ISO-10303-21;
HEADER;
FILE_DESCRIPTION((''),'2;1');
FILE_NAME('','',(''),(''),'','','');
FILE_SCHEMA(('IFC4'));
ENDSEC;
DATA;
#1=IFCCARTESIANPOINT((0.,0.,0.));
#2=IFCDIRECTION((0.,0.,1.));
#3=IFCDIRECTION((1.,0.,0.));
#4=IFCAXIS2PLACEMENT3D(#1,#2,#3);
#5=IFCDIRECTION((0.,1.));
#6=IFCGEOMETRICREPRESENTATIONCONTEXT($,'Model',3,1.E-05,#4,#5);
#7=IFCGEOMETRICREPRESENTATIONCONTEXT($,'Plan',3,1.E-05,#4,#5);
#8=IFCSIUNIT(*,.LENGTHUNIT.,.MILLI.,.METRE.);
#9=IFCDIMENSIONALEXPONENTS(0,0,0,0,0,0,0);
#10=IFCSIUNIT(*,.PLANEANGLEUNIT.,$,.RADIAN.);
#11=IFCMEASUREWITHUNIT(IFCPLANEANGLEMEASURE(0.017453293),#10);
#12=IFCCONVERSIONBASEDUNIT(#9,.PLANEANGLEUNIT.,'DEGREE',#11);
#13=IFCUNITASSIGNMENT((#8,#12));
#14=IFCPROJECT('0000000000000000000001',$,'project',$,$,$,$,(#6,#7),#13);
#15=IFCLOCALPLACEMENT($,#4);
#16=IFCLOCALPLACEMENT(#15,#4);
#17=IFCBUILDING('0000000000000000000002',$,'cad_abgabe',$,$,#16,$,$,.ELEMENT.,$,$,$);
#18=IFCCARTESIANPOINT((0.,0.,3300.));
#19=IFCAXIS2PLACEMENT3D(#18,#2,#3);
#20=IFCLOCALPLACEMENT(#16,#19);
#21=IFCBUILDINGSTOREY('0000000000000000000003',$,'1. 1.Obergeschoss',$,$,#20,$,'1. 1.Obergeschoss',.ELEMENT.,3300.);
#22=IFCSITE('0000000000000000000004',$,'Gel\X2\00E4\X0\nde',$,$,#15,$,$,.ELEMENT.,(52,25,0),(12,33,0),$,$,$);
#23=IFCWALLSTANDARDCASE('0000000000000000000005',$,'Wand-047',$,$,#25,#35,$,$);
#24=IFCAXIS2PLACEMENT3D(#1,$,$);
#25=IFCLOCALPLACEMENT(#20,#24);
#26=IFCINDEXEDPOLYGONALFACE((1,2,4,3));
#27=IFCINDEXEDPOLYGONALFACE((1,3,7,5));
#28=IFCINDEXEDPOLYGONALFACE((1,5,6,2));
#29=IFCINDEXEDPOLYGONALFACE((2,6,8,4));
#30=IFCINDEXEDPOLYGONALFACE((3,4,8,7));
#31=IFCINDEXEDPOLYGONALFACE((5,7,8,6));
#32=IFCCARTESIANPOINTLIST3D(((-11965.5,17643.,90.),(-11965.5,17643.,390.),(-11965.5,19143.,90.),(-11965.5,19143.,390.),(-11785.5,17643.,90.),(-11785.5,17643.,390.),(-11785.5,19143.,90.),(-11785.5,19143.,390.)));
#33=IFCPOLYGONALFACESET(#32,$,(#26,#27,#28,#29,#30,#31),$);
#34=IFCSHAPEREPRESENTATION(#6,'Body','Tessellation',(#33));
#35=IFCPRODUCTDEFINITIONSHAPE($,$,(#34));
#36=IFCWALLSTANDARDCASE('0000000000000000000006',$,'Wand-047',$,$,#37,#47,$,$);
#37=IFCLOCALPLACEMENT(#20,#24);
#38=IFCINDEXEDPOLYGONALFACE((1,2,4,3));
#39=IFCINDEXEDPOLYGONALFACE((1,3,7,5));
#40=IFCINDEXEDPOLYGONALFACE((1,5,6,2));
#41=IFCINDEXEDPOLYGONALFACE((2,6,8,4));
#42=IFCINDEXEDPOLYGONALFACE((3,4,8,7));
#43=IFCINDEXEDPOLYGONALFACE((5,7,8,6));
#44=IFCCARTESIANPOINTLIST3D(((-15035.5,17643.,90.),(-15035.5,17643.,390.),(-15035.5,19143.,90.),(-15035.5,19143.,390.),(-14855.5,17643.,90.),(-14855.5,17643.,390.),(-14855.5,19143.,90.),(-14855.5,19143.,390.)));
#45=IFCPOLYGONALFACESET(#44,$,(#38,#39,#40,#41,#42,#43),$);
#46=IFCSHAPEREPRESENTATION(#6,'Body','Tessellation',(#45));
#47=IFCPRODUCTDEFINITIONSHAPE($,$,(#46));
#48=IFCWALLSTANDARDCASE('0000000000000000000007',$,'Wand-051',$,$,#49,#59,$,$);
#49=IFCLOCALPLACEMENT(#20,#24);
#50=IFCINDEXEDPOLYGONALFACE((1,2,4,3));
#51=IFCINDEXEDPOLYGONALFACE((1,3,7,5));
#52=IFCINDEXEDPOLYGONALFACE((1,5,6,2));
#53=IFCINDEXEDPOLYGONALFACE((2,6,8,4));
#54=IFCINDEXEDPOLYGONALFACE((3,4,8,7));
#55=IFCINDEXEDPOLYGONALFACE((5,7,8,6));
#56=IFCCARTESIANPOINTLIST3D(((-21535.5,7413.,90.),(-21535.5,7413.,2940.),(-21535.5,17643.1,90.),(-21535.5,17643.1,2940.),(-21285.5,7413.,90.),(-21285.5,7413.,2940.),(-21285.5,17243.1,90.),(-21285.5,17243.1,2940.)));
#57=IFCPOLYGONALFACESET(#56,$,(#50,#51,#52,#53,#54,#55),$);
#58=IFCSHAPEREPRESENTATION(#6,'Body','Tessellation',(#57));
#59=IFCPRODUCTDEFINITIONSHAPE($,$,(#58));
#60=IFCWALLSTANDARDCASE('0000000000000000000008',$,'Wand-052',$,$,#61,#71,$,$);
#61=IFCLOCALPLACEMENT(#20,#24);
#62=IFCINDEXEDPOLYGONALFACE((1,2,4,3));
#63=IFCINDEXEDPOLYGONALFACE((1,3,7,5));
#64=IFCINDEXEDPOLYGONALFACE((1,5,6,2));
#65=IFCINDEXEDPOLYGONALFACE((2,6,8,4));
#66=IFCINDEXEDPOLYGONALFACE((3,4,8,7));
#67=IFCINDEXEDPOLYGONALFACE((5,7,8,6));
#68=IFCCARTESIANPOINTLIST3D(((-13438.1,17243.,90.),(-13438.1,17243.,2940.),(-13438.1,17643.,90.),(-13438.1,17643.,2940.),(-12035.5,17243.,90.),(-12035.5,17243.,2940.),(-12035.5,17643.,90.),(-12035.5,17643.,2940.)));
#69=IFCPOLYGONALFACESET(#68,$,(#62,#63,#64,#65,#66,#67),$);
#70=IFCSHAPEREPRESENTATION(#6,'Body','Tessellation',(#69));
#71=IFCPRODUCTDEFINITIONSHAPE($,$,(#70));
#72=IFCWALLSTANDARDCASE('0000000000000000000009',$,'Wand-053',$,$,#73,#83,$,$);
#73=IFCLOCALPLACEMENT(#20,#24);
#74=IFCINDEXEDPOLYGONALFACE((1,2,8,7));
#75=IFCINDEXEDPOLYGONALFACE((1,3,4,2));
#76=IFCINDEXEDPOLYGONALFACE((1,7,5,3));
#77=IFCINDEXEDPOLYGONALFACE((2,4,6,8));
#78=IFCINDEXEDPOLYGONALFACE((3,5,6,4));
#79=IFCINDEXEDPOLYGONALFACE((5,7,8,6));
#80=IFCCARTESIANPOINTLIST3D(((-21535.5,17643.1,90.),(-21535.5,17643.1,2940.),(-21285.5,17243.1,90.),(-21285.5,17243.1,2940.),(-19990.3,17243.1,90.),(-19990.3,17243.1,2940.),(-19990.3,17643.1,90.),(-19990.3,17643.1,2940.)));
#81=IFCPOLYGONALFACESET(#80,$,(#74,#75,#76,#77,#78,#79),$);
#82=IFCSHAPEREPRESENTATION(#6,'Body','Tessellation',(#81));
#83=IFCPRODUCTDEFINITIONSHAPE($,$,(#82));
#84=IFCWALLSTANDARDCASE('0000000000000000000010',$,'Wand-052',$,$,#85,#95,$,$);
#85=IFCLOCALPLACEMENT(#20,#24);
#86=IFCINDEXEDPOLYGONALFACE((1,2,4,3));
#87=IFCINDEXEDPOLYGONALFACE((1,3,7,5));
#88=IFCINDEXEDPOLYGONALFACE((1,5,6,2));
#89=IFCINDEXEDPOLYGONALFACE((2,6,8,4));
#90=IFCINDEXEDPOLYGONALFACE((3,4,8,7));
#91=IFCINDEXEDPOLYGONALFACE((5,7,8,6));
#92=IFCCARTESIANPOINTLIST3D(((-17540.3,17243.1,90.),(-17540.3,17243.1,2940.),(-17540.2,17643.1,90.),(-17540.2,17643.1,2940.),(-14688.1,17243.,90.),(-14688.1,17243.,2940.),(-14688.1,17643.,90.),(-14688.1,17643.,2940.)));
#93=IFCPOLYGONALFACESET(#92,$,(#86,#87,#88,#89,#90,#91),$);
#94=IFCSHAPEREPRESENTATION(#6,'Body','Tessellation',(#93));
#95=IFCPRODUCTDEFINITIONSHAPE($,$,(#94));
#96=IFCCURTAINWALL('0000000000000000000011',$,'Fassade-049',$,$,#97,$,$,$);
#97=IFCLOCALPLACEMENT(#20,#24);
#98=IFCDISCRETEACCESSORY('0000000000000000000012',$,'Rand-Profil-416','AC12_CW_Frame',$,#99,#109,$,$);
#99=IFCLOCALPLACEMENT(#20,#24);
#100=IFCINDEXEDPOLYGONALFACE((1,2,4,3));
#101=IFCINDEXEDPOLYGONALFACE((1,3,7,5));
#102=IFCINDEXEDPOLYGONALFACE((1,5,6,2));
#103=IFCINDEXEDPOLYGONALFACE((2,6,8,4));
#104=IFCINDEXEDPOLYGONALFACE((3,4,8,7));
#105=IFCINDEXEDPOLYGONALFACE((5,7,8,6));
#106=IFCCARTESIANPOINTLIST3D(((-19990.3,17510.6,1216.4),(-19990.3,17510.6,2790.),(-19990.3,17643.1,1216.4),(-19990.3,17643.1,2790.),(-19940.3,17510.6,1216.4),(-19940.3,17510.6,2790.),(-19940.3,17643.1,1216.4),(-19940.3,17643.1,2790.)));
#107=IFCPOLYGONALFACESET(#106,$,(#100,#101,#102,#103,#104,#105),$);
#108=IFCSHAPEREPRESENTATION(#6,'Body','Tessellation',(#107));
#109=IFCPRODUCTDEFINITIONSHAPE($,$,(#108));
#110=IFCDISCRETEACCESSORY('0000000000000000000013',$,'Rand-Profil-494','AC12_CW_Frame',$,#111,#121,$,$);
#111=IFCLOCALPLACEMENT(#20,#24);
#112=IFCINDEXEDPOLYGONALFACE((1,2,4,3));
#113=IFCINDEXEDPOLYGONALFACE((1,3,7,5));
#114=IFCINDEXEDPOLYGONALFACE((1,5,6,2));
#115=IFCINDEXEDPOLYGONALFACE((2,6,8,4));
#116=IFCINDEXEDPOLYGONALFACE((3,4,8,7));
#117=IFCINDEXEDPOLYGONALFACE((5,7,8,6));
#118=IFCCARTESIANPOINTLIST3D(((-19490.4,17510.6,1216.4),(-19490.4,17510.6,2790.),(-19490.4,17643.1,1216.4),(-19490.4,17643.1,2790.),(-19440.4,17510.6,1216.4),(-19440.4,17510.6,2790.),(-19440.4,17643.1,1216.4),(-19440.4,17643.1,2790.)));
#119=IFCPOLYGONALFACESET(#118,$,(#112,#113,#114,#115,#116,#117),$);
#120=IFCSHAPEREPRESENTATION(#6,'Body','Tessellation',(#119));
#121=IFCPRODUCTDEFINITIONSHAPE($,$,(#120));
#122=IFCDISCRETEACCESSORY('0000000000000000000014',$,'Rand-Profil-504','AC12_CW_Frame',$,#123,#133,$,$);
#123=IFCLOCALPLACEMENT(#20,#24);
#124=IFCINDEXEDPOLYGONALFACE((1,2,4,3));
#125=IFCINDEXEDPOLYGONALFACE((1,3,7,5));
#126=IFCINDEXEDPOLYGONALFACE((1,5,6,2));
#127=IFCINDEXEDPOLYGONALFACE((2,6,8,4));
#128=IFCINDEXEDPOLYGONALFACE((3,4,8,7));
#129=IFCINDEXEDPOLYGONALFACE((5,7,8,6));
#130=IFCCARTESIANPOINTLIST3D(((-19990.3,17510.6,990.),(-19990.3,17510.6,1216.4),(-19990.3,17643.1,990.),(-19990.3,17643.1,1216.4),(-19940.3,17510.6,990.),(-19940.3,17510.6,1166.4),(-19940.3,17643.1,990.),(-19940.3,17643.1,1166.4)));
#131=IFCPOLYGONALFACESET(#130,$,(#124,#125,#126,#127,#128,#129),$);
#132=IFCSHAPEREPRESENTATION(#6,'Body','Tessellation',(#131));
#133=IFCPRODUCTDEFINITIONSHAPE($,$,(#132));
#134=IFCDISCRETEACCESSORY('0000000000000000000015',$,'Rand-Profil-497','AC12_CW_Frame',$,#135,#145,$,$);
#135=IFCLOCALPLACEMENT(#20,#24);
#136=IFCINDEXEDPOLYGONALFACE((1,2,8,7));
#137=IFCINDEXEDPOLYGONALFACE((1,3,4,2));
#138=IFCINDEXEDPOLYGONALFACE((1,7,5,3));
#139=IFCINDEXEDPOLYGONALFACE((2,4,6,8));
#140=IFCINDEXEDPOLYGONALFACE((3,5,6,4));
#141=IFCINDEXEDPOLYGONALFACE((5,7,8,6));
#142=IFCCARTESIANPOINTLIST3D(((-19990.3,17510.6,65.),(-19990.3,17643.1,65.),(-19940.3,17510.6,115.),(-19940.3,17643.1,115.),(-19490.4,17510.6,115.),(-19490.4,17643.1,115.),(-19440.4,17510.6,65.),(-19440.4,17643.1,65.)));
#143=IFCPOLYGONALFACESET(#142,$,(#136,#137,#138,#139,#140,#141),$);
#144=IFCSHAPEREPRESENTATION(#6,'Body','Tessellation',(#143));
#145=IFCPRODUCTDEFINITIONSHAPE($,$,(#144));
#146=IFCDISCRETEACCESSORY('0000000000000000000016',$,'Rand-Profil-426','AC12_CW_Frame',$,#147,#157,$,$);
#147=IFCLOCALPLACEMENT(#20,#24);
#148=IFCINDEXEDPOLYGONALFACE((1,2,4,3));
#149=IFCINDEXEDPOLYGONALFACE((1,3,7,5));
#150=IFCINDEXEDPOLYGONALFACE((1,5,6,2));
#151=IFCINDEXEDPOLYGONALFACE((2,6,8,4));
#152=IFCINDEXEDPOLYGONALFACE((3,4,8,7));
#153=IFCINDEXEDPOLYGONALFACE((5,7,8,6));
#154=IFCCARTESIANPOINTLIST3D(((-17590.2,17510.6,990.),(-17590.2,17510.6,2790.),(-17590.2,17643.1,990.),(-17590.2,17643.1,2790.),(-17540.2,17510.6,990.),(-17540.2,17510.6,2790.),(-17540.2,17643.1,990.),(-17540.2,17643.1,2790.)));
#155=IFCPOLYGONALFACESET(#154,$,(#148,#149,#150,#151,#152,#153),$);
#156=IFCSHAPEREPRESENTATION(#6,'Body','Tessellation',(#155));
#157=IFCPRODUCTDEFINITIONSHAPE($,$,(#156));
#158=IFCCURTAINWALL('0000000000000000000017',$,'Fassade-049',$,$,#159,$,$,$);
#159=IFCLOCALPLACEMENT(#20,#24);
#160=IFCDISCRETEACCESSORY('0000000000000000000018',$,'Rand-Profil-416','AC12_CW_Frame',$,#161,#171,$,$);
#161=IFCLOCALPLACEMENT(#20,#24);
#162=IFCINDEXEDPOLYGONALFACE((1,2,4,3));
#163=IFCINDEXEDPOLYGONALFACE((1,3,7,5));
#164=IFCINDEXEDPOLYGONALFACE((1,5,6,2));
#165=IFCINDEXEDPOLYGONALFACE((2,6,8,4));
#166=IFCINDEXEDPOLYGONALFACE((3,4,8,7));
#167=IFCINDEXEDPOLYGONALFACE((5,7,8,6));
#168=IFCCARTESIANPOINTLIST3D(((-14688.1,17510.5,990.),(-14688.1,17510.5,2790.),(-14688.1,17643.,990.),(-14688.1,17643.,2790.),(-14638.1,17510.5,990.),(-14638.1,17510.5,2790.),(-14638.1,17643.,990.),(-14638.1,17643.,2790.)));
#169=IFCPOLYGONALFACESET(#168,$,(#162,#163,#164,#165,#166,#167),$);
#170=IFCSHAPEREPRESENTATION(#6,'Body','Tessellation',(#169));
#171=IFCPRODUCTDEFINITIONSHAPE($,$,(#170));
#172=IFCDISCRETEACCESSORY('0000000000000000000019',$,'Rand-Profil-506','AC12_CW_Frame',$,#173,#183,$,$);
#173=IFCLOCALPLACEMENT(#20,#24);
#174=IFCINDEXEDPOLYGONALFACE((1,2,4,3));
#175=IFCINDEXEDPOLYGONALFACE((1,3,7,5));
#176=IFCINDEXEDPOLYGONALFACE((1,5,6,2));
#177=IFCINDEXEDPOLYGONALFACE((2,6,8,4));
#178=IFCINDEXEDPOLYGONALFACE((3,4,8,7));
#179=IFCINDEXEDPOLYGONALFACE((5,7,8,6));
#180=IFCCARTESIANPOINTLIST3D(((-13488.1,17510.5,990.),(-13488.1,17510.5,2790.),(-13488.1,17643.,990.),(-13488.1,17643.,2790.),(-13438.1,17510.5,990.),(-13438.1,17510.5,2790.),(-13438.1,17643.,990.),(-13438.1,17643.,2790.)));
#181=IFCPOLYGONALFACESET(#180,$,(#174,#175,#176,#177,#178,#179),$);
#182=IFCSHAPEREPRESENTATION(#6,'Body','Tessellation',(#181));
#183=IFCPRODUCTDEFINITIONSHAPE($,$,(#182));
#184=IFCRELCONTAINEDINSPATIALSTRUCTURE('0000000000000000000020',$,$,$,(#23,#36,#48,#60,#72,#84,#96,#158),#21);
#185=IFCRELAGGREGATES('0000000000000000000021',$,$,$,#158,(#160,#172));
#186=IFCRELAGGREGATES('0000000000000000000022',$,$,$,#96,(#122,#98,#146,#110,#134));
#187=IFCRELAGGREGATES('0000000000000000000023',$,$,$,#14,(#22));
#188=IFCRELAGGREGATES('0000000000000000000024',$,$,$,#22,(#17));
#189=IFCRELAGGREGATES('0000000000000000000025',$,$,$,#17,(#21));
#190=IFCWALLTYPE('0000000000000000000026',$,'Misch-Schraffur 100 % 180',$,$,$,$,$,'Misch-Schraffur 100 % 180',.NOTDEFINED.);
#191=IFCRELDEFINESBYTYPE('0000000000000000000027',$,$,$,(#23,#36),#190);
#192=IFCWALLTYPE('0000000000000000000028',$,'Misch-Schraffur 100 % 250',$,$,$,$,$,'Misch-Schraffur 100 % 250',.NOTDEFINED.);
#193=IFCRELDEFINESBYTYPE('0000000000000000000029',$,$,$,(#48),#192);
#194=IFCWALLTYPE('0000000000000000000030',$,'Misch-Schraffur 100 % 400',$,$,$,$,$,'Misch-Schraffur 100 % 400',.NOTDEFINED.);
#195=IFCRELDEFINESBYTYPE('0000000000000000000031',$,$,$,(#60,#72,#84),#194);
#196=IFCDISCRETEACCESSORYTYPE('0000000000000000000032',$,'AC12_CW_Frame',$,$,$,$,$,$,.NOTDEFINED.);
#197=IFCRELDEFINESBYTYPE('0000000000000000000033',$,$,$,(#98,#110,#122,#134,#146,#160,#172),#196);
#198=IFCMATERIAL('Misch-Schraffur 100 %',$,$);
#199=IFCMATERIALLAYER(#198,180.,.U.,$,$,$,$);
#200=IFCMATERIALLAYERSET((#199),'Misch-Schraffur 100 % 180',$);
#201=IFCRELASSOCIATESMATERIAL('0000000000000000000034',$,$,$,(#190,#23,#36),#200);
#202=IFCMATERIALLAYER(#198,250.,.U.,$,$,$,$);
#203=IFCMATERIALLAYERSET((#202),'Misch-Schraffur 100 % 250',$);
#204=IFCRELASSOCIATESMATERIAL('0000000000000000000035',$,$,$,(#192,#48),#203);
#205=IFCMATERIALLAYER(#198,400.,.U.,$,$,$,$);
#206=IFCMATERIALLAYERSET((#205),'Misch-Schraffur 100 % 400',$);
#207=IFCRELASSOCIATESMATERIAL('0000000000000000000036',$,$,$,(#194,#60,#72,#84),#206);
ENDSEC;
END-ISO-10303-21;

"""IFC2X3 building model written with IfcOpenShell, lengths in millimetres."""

from ifc_helpers import new_model, entity, si_unit, converted_unit, direction, frame, origin_with_axes, place, context, project, spatial, polyline, outline, extrude, source, transform, mapped, material, layer, layer_set, layer_usage, type_object, element, aggregate, save


model = new_model("IFC2X3")

# Units and contexts
model_context = context("Model", 3, precision=1e-05, world=origin_with_axes(), true_north=direction((0.0, 1.0)))
plan_context = context("Plan", 3, precision=1e-05, world=origin_with_axes(), true_north=direction((0.0, 1.0)))
ifc_project = project(units=[si_unit("LENGTHUNIT", "METRE", prefix="MILLI"), converted_unit("PLANEANGLEUNIT", "DEGREE", entity("IfcPlaneAngleMeasure", 0.017453293), si_unit("PLANEANGLEUNIT", "RADIAN"), dimensions=[0, 0, 0, 0, 0, 0, 0])], contexts=[model_context, plan_context])

# Site, building, storey
site_placement = place(None, origin_with_axes())
site = spatial("IfcSite", under=ifc_project, at=site_placement, Name="Gelände", CompositionType="ELEMENT", RefLatitude=(52, 25, 0), RefLongitude=(12, 33, 0))
building_placement = place(site_placement, origin_with_axes())
building = spatial("IfcBuilding", under=site, at=building_placement, Name="cad_abgabe", CompositionType="ELEMENT")
storey_placement = place(building_placement, frame((0.0, 0.0, 3300.0), z_axis=(0.0, 0.0, 1.0), x_axis=(1.0, 0.0, 0.0)))
storey = spatial("IfcBuildingStorey", under=building, at=storey_placement, Name="1. 1.Obergeschoss", LongName="1. 1.Obergeschoss", CompositionType="ELEMENT", Elevation=3300.0)

# Walls
ifc_material = material(Name="Misch-Schraffur 100 %")
ifc_layer_1 = layer(ifc_material, 180.0, ventilated="UNKNOWN")
ifc_layer_set_1 = layer_set([ifc_layer_1], Name="Misch-Schraffur 100 % 180")
ifc_layer_usage_1 = layer_usage(ifc_layer_set_1, "AXIS2", "POSITIVE", 0.0)
wall_type_1 = type_object("IfcWallType", Name="Misch-Schraffur 100 % 180", ElementType="Misch-Schraffur 100 % 180", PredefinedType="NOTDEFINED", material=ifc_layer_set_1)
wall_1_placement = place(storey_placement, frame((-11785.5, 17643.0, 90.0), z_axis=(0.0, 0.0, 1.0), x_axis=(0.0, 1.0, 0.0)))
element("IfcWallStandardCase", 1, at=wall_1_placement, inside=storey, type_object=wall_type_1, material=ifc_layer_usage_1, Name="Wand-047", context=model_context, shape_type="SweptSolid", body=[
    extrude(outline(polyline([(0.0, 0.0), (1500.0, 0.0), (1500.0, 180.0), (0.0, 180.0), (0.0, 0.0)])), origin_with_axes(), (0.0, 0.0, 1.0), 300.0),
])
ifc_layer_usage_2 = layer_usage(ifc_layer_set_1, "AXIS2", "POSITIVE", 0.0)
wall_2_placement = place(storey_placement, frame((-15035.5, 19143.0, 90.0), z_axis=(0.0, 0.0, 1.0), x_axis=(0.0, -1.0, 0.0)))
element("IfcWallStandardCase", 2, at=wall_2_placement, inside=storey, type_object=wall_type_1, material=ifc_layer_usage_2, Name="Wand-047", context=model_context, shape_type="SweptSolid", body=[
    extrude(outline(polyline([(0.0, 0.0), (1500.0, 0.0), (1500.0, 180.0), (0.0, 180.0), (0.0, 0.0)])), origin_with_axes(), (0.0, 0.0, 1.0), 300.0),
])
ifc_layer_2 = layer(ifc_material, 250.0, ventilated="UNKNOWN")
ifc_layer_set_2 = layer_set([ifc_layer_2], Name="Misch-Schraffur 100 % 250")
ifc_layer_usage_3 = layer_usage(ifc_layer_set_2, "AXIS2", "POSITIVE", 0.0)
wall_type_2 = type_object("IfcWallType", Name="Misch-Schraffur 100 % 250", ElementType="Misch-Schraffur 100 % 250", PredefinedType="NOTDEFINED", material=ifc_layer_set_2)
wall_3_placement = place(storey_placement, frame((-21535.5, 17643.1, 90.0), z_axis=(0.0, 0.0, 1.0), x_axis=(0.0, -1.0, 0.0)))
element("IfcWallStandardCase", 3, at=wall_3_placement, inside=storey, type_object=wall_type_2, material=ifc_layer_usage_3, Name="Wand-051", context=model_context, shape_type="SweptSolid", body=[
    extrude(outline(polyline([(0.0, 0.0), (10230.1, 0.0), (10230.1, 250.0), (400.0, 250.0), (0.0, 0.0)])), origin_with_axes(), (0.0, 0.0, 1.0), 2850.0),
])
ifc_layer_3 = layer(ifc_material, 400.0, ventilated="UNKNOWN")
ifc_layer_set_3 = layer_set([ifc_layer_3], Name="Misch-Schraffur 100 % 400")
ifc_layer_usage_4 = layer_usage(ifc_layer_set_3, "AXIS2", "POSITIVE", 0.0)
wall_type_3 = type_object("IfcWallType", Name="Misch-Schraffur 100 % 400", ElementType="Misch-Schraffur 100 % 400", PredefinedType="NOTDEFINED", material=ifc_layer_set_3)
wall_4_placement = place(storey_placement, frame((-12035.5, 17643.0, 90.0), z_axis=(0.0, 0.0, 1.0), x_axis=(-1.0, 0.0, 0.0)))
element("IfcWallStandardCase", 4, at=wall_4_placement, inside=storey, type_object=wall_type_3, material=ifc_layer_usage_4, Name="Wand-052", context=model_context, shape_type="SweptSolid", body=[
    extrude(outline(polyline([(0.0, 0.0), (1402.7, 0.0), (1402.7, 400.0), (0.0, 400.0), (0.0, 0.0)])), origin_with_axes(), (0.0, 0.0, 1.0), 2850.0),
])
ifc_layer_usage_5 = layer_usage(ifc_layer_set_3, "AXIS2", "POSITIVE", 0.0)
wall_5_placement = place(storey_placement, frame((-19990.3, 17643.1, 90.0), z_axis=(0.0, 0.0, 1.0), x_axis=(-1.0, 0.0, 0.0)))
element("IfcWallStandardCase", 5, at=wall_5_placement, inside=storey, type_object=wall_type_3, material=ifc_layer_usage_5, Name="Wand-053", context=model_context, shape_type="SweptSolid", body=[
    extrude(outline(polyline([(0.0, 0.0), (1545.2, 0.0), (1295.2, 400.0), (0.0, 400.0), (0.0, 0.0)])), origin_with_axes(), (0.0, 0.0, 1.0), 2850.0),
])
ifc_layer_usage_6 = layer_usage(ifc_layer_set_3, "AXIS2", "POSITIVE", 0.0)
wall_6_placement = place(storey_placement, frame((-14688.1, 17643.0, 90.0), z_axis=(0.0, 0.0, 1.0), x_axis=(-1.0, 0.000034, 0.0)))
element("IfcWallStandardCase", 6, at=wall_6_placement, inside=storey, type_object=wall_type_3, material=ifc_layer_usage_6, Name="Wand-052", context=model_context, shape_type="SweptSolid", body=[
    extrude(outline(polyline([(0.0, 0.0), (2852.1, 0.0), (2852.1, 400.0), (0.0, 400.0), (0.0, 0.0)])), origin_with_axes(), (0.0, 0.0, 1.0), 2850.0),
])

# Curtain walls, discrete accessories
curtain_wall_1_placement = place(storey_placement, frame((-19965.3, 17588.1, 90.0), z_axis=(0.0, 0.0, 1.0), x_axis=(1.0, 0.0, 0.0)))
curtain_wall_1 = element("IfcCurtainWall", 7, at=curtain_wall_1_placement, inside=storey, Name="Fassade-049")
discrete_accessory_type = type_object("IfcDiscreteAccessoryType", Name="AC12_CW_Frame")
shared_shape_1 = source(origin_with_axes(), model_context, "Body", "SweptSolid", [
    extrude(outline(polyline([(0.0, 0.0), (1573.6, 0.0), (1573.6, -132.5), (0.0, -132.5), (0.0, 0.0)])), origin_with_axes(), (0.0, 0.0, 1.0), 50.0),
])
discrete_accessory_1_placement = place(storey_placement, frame((-19990.3, 17510.6, 1216.4), z_axis=(1.0, 0.0, 0.0), x_axis=(0.0, 0.0, 1.0)))
discrete_accessory_1 = element("IfcDiscreteAccessory", 8, at=discrete_accessory_1_placement, type_object=discrete_accessory_type, Name="Rand-Profil-416", Description="AC12_CW_Frame", context=model_context, shape_type="MappedRepresentation", body=[
    mapped(shared_shape_1, transform((0.0, 0.0, 0.0), scale=1.0)),
])
discrete_accessory_2_placement = place(storey_placement, frame((-19490.4, 17510.6, 1216.4), z_axis=(1.0, 0.0, 0.0), x_axis=(0.0, 0.0, 1.0)))
discrete_accessory_2 = element("IfcDiscreteAccessory", 9, at=discrete_accessory_2_placement, type_object=discrete_accessory_type, Name="Rand-Profil-494", Description="AC12_CW_Frame", context=model_context, shape_type="MappedRepresentation", body=[
    mapped(shared_shape_1, transform((0.0, 0.0, 0.0), scale=1.0)),
])
shared_shape_2 = source(origin_with_axes(), model_context, "Body", "SweptSolid", [
    extrude(outline(polyline([(0.0, 0.0), (176.4, 0.0), (226.4, -50.0), (0.0, -50.0), (0.0, 0.0)])), origin_with_axes(), (0.0, 0.0, 1.0), 132.5),
])
discrete_accessory_3_placement = place(storey_placement, frame((-19940.3, 17510.6, 990.0), z_axis=(0.0, 1.0, 0.0), x_axis=(0.0, 0.0, 1.0)))
discrete_accessory_3 = element("IfcDiscreteAccessory", 10, at=discrete_accessory_3_placement, type_object=discrete_accessory_type, Name="Rand-Profil-504", Description="AC12_CW_Frame", context=model_context, shape_type="MappedRepresentation", body=[
    mapped(shared_shape_2, transform((0.0, 0.0, 0.0), scale=1.0)),
])
shared_shape_3 = source(origin_with_axes(), model_context, "Body", "SweptSolid", [
    extrude(outline(polyline([(0.0, 0.0), (549.9, 0.0), (499.9, -50.0), (50.0, -50.0), (0.0, 0.0)])), origin_with_axes(), (0.0, 0.0, 1.0), 132.5),
])
discrete_accessory_4_placement = place(storey_placement, frame((-19990.3, 17510.6, 65.0), z_axis=(0.0, 1.0, 0.0), x_axis=(1.0, 0.0, 0.0)))
discrete_accessory_4 = element("IfcDiscreteAccessory", 11, at=discrete_accessory_4_placement, type_object=discrete_accessory_type, Name="Rand-Profil-497", Description="AC12_CW_Frame", context=model_context, shape_type="MappedRepresentation", body=[
    mapped(shared_shape_3, transform((0.0, 0.0, 0.0), scale=1.0)),
])
shared_shape_4 = source(origin_with_axes(), model_context, "Body", "SweptSolid", [
    extrude(outline(polyline([(0.0, 0.0), (1800.0, 0.0), (1800.0, -132.5), (0.0, -132.5), (0.0, 0.0)])), origin_with_axes(), (0.0, 0.0, 1.0), 50.0),
])
discrete_accessory_5_placement = place(storey_placement, frame((-17590.2, 17510.6, 990.0), z_axis=(1.0, 0.0, 0.0), x_axis=(0.0, 0.0, 1.0)))
discrete_accessory_5 = element("IfcDiscreteAccessory", 12, at=discrete_accessory_5_placement, type_object=discrete_accessory_type, Name="Rand-Profil-426", Description="AC12_CW_Frame", context=model_context, shape_type="MappedRepresentation", body=[
    mapped(shared_shape_4, transform((0.0, 0.0, 0.0), scale=1.0)),
])
curtain_wall_2_placement = place(storey_placement, frame((-14663.1, 17588.0, 90.0), z_axis=(0.0, 0.0, 1.0), x_axis=(1.0, 0.0, 0.0)))
curtain_wall_2 = element("IfcCurtainWall", 13, at=curtain_wall_2_placement, inside=storey, Name="Fassade-049")
discrete_accessory_6_placement = place(storey_placement, frame((-14688.1, 17510.5, 990.0), z_axis=(1.0, 0.0, 0.0), x_axis=(0.0, 0.0, 1.0)))
discrete_accessory_6 = element("IfcDiscreteAccessory", 14, at=discrete_accessory_6_placement, type_object=discrete_accessory_type, Name="Rand-Profil-416", Description="AC12_CW_Frame", context=model_context, shape_type="MappedRepresentation", body=[
    mapped(shared_shape_4, transform((0.0, 0.0, 0.0), scale=1.0)),
])
discrete_accessory_7_placement = place(storey_placement, frame((-13488.1, 17510.5, 990.0), z_axis=(1.0, 0.0, 0.0), x_axis=(0.0, 0.0, 1.0)))
discrete_accessory_7 = element("IfcDiscreteAccessory", 15, at=discrete_accessory_7_placement, type_object=discrete_accessory_type, Name="Rand-Profil-506", Description="AC12_CW_Frame", context=model_context, shape_type="MappedRepresentation", body=[
    mapped(shared_shape_4, transform((0.0, 0.0, 0.0), scale=1.0)),
])

aggregate(curtain_wall_2, [discrete_accessory_6, discrete_accessory_7])
aggregate(curtain_wall_1, [discrete_accessory_3, discrete_accessory_1, discrete_accessory_5, discrete_accessory_2, discrete_accessory_4])

save(model, "model.ifc")
